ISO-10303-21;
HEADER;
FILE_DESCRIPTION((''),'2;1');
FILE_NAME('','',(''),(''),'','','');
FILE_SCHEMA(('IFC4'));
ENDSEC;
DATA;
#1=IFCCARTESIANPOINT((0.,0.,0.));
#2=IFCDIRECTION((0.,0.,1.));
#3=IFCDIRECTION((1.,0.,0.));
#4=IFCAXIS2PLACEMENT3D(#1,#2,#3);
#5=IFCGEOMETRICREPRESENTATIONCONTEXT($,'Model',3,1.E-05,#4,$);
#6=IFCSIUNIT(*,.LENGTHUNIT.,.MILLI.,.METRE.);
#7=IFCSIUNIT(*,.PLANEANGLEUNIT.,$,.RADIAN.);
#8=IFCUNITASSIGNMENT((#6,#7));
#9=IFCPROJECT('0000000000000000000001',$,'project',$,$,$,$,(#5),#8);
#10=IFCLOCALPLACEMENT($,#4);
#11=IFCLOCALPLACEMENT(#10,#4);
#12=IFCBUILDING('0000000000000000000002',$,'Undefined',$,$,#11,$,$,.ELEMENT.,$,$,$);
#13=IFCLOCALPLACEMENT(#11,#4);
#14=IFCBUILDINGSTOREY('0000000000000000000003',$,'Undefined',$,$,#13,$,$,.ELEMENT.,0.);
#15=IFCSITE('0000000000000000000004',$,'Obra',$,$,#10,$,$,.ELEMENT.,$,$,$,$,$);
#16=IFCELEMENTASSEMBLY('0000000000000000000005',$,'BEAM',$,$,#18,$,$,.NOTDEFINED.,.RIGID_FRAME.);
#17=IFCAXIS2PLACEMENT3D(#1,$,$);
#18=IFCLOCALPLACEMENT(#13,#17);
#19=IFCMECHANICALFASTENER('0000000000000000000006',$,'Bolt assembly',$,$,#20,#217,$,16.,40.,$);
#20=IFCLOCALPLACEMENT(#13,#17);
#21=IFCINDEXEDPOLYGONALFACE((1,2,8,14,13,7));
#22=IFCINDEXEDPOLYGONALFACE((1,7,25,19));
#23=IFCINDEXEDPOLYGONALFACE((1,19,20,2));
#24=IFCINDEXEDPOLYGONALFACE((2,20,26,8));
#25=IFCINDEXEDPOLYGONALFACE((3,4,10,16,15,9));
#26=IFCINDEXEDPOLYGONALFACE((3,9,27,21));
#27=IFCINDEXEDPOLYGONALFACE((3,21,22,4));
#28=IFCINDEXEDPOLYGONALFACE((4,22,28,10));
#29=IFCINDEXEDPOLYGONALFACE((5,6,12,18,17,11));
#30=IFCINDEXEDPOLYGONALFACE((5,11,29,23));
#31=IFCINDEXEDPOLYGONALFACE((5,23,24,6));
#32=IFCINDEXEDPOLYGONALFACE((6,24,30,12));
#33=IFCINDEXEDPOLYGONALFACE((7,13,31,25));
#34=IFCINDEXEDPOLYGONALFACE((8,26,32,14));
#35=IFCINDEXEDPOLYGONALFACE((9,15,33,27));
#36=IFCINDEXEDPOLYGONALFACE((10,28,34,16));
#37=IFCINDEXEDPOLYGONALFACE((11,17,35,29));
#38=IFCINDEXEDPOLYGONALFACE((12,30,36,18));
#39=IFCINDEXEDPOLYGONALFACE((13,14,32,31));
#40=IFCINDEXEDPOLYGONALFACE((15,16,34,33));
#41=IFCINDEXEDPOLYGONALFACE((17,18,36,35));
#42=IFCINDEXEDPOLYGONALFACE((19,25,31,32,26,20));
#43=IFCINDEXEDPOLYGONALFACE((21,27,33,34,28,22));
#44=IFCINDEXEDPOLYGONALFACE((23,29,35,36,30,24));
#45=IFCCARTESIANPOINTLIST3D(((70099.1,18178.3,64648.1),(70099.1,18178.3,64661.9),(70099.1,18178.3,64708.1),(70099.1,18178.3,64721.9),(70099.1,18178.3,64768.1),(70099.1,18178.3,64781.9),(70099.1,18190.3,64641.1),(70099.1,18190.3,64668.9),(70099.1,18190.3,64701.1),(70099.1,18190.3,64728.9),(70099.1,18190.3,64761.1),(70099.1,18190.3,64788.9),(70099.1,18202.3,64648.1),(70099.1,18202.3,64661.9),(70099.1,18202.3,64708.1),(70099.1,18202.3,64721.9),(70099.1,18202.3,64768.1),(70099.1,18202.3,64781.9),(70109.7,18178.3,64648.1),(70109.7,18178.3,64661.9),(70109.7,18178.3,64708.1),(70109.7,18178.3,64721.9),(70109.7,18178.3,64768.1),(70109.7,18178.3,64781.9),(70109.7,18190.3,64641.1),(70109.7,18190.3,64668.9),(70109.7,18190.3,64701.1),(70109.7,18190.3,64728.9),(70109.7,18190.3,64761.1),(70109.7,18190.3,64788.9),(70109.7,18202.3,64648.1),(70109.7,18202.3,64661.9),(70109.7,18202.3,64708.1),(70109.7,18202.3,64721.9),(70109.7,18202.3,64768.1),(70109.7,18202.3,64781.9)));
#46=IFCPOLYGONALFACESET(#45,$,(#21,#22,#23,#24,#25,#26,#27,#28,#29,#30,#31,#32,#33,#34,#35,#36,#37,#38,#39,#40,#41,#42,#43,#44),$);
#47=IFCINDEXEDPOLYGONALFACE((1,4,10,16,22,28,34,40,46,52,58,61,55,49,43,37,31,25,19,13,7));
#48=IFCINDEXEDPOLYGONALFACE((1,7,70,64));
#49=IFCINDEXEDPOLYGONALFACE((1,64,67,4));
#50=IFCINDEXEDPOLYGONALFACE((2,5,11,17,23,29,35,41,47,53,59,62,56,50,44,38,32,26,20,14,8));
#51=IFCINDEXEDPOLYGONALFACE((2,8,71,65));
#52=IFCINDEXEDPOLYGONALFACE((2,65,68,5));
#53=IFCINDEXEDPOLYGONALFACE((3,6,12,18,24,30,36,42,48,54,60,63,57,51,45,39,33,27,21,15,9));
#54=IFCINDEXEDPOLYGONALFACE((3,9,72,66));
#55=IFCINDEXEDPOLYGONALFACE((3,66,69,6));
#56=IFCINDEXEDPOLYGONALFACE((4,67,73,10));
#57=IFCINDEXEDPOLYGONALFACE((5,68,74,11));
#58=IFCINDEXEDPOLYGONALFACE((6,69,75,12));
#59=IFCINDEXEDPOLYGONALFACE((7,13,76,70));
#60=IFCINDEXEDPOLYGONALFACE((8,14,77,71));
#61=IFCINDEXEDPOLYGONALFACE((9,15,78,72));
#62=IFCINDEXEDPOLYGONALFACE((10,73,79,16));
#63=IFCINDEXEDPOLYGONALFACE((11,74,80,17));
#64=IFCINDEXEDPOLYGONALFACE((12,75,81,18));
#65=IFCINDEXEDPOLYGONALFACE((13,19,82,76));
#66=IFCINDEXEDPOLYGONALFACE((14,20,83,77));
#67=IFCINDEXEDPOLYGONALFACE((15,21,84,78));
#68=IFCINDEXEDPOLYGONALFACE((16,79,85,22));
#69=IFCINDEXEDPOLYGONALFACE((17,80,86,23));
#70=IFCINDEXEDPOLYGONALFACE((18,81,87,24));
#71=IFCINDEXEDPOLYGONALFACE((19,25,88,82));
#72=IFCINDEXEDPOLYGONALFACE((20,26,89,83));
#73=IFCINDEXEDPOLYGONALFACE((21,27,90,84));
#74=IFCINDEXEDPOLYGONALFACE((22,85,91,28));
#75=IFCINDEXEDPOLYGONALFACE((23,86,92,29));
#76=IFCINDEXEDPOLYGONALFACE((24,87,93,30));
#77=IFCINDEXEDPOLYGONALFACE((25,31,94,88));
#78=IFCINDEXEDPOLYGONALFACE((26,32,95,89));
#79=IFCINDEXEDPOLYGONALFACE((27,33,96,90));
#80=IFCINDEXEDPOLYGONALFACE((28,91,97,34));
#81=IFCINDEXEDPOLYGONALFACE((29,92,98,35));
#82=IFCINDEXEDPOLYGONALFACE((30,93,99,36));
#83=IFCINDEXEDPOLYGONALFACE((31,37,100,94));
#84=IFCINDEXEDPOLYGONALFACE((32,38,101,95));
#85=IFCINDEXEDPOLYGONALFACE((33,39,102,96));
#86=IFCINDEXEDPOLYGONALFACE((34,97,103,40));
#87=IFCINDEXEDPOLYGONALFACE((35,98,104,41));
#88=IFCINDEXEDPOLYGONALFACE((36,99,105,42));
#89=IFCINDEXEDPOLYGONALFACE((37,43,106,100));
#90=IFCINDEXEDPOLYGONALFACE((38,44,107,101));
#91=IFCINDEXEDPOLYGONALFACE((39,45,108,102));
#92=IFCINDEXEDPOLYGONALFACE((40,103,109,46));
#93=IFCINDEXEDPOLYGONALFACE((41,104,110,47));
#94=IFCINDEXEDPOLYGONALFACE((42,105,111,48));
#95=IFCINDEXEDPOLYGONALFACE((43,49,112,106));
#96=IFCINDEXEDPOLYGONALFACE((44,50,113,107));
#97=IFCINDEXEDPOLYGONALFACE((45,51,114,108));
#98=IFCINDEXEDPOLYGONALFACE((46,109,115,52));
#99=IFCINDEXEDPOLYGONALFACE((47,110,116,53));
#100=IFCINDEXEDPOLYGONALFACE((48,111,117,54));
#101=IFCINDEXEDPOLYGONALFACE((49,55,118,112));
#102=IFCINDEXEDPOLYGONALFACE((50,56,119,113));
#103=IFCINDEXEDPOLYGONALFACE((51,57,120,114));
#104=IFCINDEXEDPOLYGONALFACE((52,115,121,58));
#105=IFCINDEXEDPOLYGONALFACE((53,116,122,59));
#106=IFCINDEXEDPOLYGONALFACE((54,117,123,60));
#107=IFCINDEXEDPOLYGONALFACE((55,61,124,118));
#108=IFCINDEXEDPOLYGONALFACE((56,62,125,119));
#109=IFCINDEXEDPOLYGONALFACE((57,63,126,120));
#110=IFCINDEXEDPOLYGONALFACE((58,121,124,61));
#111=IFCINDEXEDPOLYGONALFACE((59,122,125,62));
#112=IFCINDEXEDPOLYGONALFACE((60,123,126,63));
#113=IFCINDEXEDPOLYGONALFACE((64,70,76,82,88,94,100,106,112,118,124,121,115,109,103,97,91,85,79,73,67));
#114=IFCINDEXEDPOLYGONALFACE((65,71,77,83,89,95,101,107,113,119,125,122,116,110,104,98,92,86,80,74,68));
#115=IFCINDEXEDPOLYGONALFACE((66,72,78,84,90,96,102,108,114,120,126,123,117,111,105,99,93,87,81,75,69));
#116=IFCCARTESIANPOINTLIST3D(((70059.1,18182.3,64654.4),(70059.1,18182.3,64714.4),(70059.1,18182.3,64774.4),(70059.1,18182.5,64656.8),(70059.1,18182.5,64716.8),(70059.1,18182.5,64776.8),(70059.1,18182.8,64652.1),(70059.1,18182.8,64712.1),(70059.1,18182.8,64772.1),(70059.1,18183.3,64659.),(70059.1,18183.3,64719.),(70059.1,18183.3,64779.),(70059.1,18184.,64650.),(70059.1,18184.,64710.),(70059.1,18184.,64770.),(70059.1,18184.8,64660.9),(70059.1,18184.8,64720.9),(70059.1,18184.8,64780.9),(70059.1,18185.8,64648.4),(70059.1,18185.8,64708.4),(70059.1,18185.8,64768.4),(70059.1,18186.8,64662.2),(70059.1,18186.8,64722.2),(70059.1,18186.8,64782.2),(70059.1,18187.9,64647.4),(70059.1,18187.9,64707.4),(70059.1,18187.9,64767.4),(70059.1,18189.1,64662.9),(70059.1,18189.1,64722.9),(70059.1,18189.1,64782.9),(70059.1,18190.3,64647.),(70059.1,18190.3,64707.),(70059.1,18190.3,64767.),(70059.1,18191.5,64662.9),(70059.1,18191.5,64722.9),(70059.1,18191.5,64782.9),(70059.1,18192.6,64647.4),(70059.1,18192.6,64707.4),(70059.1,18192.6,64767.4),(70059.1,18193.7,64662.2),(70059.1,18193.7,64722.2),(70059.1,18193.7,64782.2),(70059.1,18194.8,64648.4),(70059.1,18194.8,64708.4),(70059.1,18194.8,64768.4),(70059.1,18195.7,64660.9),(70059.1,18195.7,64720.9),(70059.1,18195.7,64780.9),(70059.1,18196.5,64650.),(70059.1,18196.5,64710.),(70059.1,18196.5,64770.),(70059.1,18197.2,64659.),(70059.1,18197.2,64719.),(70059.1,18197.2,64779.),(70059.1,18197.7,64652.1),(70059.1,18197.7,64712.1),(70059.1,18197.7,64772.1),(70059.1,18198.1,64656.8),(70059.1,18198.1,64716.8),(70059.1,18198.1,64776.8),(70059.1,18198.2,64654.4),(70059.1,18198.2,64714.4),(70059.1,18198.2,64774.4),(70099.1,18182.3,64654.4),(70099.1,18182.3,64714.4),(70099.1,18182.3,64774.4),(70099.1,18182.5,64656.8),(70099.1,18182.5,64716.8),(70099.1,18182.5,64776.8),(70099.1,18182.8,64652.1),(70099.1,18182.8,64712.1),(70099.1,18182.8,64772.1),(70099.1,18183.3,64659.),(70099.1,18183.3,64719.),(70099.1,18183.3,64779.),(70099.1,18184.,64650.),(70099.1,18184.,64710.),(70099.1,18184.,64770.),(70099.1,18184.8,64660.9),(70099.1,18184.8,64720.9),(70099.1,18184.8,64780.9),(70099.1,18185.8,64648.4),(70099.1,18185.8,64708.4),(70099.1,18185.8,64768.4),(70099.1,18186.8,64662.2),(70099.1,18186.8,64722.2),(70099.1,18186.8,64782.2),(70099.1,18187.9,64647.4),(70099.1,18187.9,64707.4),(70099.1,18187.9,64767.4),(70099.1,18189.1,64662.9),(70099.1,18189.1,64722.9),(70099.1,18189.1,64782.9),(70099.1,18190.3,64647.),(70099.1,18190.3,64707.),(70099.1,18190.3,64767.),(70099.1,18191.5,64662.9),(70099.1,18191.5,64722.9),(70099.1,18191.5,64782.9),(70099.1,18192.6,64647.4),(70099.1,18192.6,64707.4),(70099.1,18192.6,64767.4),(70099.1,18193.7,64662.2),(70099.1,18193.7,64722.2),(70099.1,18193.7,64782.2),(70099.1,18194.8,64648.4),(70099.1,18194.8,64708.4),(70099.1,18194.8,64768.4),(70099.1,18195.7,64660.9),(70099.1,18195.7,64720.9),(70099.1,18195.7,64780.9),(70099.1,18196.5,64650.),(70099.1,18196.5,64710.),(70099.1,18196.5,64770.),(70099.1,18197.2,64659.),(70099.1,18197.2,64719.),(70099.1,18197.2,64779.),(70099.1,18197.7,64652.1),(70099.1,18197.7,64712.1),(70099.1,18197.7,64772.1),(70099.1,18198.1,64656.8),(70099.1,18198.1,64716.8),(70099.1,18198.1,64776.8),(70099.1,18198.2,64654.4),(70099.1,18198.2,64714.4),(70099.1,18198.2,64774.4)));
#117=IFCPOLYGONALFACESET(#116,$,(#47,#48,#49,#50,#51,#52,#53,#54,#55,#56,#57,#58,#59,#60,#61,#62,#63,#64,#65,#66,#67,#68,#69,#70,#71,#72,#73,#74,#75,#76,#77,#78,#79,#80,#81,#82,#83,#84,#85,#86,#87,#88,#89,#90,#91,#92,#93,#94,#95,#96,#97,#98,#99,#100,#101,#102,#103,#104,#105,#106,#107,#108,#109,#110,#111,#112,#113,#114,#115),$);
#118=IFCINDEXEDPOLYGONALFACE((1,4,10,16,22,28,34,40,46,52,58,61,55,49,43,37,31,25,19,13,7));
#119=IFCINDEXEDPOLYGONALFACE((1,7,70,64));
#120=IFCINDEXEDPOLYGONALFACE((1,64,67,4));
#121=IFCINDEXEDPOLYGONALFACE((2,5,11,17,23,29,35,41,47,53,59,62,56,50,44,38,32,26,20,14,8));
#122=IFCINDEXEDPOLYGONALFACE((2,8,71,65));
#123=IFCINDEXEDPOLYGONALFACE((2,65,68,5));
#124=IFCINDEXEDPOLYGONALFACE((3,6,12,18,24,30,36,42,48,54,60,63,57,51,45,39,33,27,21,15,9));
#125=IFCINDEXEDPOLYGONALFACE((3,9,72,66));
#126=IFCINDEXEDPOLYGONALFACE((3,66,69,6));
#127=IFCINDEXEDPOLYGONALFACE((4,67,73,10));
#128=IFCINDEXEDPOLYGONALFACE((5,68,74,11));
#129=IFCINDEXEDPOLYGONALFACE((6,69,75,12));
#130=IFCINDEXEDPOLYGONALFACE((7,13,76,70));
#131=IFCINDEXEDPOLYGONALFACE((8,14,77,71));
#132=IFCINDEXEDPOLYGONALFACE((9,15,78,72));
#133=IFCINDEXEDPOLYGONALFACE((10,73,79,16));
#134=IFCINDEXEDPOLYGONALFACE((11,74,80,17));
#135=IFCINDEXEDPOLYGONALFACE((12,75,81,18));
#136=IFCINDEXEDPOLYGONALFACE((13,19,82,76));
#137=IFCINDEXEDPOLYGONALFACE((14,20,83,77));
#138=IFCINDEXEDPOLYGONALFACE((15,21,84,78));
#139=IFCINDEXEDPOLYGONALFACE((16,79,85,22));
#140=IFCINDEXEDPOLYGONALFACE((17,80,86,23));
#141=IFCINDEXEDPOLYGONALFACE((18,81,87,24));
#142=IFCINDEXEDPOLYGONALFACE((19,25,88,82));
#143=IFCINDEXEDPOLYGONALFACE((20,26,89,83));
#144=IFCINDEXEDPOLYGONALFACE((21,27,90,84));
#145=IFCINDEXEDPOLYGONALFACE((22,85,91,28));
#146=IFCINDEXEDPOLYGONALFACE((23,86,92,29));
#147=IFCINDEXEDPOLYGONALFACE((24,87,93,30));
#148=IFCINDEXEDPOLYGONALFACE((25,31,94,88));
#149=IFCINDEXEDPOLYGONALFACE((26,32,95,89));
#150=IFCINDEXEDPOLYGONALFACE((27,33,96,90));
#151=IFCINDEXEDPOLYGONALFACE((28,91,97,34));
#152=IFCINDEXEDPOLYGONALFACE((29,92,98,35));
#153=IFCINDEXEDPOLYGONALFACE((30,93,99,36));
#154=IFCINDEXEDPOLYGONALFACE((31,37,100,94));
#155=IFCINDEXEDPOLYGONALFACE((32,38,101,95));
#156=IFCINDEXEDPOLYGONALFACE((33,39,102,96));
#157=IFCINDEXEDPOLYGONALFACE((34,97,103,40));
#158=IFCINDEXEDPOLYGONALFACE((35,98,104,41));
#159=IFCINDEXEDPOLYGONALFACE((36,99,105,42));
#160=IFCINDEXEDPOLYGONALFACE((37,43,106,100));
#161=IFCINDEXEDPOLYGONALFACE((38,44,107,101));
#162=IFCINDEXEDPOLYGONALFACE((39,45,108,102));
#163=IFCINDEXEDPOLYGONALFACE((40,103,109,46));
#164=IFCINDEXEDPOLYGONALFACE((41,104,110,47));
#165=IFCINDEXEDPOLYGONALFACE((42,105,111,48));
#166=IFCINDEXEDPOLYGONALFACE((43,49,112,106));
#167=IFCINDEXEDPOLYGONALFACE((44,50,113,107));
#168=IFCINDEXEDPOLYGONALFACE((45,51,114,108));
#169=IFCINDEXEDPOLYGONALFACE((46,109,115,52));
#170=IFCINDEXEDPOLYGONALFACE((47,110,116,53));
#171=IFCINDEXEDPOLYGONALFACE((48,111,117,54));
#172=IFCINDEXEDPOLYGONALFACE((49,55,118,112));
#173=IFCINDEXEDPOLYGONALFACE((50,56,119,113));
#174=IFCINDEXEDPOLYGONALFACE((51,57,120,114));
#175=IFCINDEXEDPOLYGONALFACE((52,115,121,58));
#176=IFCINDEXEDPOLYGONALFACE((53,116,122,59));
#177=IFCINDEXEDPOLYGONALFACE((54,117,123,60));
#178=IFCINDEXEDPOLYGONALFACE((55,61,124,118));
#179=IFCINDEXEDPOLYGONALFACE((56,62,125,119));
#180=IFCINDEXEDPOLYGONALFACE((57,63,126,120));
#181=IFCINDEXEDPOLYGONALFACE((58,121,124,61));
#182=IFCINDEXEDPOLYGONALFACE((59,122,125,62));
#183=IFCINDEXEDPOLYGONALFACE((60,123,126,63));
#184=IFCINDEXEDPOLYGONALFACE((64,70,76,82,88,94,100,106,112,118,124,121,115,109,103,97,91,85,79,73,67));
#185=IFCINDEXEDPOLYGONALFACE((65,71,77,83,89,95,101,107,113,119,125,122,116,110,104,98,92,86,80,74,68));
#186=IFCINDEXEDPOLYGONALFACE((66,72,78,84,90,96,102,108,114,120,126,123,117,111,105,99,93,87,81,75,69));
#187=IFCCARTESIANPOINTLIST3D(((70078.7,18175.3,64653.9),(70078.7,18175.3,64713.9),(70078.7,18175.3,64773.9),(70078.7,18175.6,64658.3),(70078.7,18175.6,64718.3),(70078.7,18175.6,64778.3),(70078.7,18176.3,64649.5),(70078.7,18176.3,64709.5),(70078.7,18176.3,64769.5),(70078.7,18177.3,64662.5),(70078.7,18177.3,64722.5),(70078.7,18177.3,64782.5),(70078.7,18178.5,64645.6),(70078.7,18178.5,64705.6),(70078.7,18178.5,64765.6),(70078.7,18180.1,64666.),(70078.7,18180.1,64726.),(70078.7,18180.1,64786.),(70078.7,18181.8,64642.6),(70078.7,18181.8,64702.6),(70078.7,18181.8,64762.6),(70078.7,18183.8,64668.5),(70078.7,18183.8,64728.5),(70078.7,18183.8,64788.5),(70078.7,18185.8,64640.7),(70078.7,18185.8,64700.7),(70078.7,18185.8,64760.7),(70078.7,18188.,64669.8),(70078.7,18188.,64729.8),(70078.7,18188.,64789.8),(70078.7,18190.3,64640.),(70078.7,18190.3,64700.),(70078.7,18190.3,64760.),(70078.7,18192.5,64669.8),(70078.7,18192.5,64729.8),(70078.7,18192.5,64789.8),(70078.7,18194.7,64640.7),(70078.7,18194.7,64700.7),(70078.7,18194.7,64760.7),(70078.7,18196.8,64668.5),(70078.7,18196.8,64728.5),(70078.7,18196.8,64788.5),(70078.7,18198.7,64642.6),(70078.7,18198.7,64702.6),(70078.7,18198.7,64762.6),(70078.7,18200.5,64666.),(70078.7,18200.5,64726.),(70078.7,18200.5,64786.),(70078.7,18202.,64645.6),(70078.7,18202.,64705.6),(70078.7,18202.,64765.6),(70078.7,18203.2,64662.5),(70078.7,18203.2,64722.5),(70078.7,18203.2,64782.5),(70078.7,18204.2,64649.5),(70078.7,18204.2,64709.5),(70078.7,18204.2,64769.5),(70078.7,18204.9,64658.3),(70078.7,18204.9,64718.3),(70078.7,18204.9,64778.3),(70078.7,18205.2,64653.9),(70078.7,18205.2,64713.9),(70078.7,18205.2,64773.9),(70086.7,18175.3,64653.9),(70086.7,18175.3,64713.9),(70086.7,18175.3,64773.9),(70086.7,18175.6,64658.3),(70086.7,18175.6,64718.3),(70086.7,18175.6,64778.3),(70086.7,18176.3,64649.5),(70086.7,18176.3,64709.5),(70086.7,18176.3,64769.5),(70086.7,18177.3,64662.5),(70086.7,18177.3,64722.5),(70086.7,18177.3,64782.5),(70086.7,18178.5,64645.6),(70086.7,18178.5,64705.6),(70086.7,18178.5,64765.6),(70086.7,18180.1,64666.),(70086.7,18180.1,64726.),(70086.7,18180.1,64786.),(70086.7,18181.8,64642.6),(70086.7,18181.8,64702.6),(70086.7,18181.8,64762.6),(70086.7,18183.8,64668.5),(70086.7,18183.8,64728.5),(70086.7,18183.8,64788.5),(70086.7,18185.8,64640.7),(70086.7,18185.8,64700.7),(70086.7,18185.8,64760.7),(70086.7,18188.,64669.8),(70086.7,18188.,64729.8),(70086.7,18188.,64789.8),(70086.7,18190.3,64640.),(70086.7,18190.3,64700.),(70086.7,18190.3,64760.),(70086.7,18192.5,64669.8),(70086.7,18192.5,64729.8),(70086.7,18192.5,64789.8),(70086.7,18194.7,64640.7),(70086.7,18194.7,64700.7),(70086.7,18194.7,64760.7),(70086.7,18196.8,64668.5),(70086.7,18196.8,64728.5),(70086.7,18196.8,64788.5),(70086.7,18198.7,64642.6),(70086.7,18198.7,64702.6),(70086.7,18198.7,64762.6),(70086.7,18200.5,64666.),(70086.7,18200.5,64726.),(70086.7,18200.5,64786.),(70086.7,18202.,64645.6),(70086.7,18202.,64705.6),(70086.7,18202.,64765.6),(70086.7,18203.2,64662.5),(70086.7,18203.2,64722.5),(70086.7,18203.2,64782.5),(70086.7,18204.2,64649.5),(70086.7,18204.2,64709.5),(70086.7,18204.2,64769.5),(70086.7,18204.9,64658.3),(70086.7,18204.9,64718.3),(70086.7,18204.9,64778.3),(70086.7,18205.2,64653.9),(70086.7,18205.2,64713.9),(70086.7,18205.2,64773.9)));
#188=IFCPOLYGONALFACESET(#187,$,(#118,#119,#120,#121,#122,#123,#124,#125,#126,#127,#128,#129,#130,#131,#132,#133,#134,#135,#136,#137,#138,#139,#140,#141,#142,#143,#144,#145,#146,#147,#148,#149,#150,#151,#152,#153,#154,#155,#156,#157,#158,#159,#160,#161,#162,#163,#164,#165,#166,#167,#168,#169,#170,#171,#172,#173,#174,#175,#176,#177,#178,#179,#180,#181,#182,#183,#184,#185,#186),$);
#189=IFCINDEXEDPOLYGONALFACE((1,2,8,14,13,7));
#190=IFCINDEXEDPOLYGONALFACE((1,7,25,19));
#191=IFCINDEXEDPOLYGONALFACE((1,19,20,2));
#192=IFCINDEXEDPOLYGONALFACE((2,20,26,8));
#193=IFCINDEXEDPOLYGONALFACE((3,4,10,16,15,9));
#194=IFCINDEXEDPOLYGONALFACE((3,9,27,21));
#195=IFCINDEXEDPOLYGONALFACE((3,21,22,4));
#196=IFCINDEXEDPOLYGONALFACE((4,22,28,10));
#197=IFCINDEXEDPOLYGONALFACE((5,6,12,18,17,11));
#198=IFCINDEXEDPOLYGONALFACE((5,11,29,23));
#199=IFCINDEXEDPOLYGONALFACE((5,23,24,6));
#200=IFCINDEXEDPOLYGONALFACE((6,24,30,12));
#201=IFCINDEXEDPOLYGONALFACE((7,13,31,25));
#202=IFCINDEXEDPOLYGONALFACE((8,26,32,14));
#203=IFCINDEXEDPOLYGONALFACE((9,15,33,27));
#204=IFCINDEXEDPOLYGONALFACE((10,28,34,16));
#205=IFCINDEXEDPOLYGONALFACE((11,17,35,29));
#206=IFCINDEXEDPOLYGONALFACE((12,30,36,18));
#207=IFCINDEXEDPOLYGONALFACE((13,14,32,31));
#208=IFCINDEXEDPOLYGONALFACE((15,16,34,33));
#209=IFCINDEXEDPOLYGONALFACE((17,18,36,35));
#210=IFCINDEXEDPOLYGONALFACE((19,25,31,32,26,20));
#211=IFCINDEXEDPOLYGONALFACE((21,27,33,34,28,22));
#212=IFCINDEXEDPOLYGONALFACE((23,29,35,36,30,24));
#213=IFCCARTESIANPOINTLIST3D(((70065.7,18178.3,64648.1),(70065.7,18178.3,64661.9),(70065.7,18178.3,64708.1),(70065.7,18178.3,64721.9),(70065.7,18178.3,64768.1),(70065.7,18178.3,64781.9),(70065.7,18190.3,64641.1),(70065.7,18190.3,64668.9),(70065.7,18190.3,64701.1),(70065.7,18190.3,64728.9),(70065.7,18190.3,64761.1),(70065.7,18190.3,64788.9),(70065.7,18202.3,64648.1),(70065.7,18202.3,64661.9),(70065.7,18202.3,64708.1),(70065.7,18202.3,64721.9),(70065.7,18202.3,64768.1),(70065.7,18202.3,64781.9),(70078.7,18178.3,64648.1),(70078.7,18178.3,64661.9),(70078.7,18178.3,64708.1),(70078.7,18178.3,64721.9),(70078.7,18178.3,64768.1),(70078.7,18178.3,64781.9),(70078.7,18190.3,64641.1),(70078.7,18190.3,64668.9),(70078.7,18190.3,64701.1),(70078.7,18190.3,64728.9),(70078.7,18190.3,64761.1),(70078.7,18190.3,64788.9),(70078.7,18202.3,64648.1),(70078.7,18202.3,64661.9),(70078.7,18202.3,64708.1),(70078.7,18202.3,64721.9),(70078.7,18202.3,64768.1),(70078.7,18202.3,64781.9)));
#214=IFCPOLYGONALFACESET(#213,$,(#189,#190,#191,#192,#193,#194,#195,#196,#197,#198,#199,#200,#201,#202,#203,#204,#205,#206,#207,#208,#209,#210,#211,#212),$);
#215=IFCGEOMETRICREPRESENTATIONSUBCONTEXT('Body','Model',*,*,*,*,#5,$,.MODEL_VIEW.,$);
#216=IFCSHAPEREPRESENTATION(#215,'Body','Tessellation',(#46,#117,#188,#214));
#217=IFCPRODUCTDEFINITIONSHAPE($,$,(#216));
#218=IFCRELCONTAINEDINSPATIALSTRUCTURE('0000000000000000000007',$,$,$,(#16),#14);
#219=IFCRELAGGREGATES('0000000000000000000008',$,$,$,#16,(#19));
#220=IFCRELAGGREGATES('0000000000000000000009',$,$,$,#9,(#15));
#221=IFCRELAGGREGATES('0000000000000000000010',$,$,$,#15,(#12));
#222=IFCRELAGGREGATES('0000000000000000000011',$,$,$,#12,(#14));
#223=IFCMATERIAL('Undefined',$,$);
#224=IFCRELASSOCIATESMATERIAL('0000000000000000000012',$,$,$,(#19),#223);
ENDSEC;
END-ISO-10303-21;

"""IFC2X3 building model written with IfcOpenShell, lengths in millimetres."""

from ifc_helpers import new_model, si_unit, frame, origin_with_axes, origin_2d_with_axis, place, context, subcontext, project, spatial, polyline, circle, outline, extrude, source, transform, mapped, material, element, aggregate, save


model = new_model("IFC2X3")

# Units and contexts
model_context = context("Model", 3, precision=1e-05, world=origin_with_axes())
body_context = subcontext(model_context, "Body", "Model", "MODEL_VIEW")
ifc_project = project(units=[si_unit("LENGTHUNIT", "METRE", prefix="MILLI"), si_unit("PLANEANGLEUNIT", "RADIAN")], contexts=[model_context])

# Site, building, storey
site_placement = place(None, origin_with_axes())
site = spatial("IfcSite", under=ifc_project, at=site_placement, Name="Obra", CompositionType="ELEMENT")
building_placement = place(site_placement, origin_with_axes())
building = spatial("IfcBuilding", under=site, at=building_placement, Name="Undefined", CompositionType="ELEMENT")
storey_placement = place(building_placement, origin_with_axes())
storey = spatial("IfcBuildingStorey", under=building, at=storey_placement, Name="Undefined", CompositionType="ELEMENT", Elevation=0.0)

# Element assembly, mechanical fastener
ifc_material_1 = material(Name="Undefined")
assembly_1_placement = place(storey_placement, origin_with_axes())
assembly_1 = element("IfcElementAssembly", 1, at=assembly_1_placement, inside=storey, Name="BEAM", AssemblyPlace="NOTDEFINED", PredefinedType="RIGID_FRAME")
shared_shape_1 = source(origin_with_axes(), body_context, "Body", "SweptSolid", [
    extrude(outline(polyline([(13.9, 0.0), (6.9, 12.0), (-6.9, 12.0), (-13.9, 0.0), (-6.9, -12.0), (6.9, -12.0), (13.9, 0.0)])), frame((0.0, -19.7, 0.0), z_axis=(0.0, 1.0, 0.0), x_axis=(1.0, 0.0, 0.0)), (0.0, 0.0, 1.0), 10.6),
    extrude(circle(Radius=8.0, at=origin_2d_with_axis()), frame((0.0, -9.1, 0.0), z_axis=(0.0, 1.0, 0.0), x_axis=(1.0, 0.0, 0.0)), (0.0, 0.0, 1.0), 40.0),
    extrude(circle(Radius=15.0, at=origin_2d_with_axis()), frame((0.0, 3.3, 0.0), z_axis=(0.0, 1.0, 0.0), x_axis=(1.0, 0.0, 0.0)), (0.0, 0.0, 1.0), 8.0),
    extrude(outline(polyline([(13.9, 0.0), (6.9, 12.0), (-6.9, 12.0), (-13.9, 0.0), (-6.9, -12.0), (6.9, -12.0), (13.9, 0.0)])), frame((0.0, 11.3, 0.0), z_axis=(0.0, 1.0, 0.0), x_axis=(1.0, 0.0, 0.0)), (0.0, 0.0, 1.0), 13.0),
])
mechanical_fastener_1_placement = place(assembly_1_placement, frame((70090.0, 18140.3, 64835.0), z_axis=(0.0, 1.0, 0.0), x_axis=(0.0, 0.0, -1.0)))
mechanical_fastener_1 = element("IfcMechanicalFastener", 2, at=mechanical_fastener_1_placement, material=ifc_material_1, Name="Bolt assembly", NominalDiameter=16.0, NominalLength=40.0, context=body_context, shape_type="MappedRepresentation", body=[
    mapped(shared_shape_1, transform((60.0, 0.0, 50.0))),
    mapped(shared_shape_1, transform((120.0, 0.0, 50.0))),
    mapped(shared_shape_1, transform((180.0, 0.0, 50.0))),
])

aggregate(assembly_1, [mechanical_fastener_1])

save(model, "model.ifc")
